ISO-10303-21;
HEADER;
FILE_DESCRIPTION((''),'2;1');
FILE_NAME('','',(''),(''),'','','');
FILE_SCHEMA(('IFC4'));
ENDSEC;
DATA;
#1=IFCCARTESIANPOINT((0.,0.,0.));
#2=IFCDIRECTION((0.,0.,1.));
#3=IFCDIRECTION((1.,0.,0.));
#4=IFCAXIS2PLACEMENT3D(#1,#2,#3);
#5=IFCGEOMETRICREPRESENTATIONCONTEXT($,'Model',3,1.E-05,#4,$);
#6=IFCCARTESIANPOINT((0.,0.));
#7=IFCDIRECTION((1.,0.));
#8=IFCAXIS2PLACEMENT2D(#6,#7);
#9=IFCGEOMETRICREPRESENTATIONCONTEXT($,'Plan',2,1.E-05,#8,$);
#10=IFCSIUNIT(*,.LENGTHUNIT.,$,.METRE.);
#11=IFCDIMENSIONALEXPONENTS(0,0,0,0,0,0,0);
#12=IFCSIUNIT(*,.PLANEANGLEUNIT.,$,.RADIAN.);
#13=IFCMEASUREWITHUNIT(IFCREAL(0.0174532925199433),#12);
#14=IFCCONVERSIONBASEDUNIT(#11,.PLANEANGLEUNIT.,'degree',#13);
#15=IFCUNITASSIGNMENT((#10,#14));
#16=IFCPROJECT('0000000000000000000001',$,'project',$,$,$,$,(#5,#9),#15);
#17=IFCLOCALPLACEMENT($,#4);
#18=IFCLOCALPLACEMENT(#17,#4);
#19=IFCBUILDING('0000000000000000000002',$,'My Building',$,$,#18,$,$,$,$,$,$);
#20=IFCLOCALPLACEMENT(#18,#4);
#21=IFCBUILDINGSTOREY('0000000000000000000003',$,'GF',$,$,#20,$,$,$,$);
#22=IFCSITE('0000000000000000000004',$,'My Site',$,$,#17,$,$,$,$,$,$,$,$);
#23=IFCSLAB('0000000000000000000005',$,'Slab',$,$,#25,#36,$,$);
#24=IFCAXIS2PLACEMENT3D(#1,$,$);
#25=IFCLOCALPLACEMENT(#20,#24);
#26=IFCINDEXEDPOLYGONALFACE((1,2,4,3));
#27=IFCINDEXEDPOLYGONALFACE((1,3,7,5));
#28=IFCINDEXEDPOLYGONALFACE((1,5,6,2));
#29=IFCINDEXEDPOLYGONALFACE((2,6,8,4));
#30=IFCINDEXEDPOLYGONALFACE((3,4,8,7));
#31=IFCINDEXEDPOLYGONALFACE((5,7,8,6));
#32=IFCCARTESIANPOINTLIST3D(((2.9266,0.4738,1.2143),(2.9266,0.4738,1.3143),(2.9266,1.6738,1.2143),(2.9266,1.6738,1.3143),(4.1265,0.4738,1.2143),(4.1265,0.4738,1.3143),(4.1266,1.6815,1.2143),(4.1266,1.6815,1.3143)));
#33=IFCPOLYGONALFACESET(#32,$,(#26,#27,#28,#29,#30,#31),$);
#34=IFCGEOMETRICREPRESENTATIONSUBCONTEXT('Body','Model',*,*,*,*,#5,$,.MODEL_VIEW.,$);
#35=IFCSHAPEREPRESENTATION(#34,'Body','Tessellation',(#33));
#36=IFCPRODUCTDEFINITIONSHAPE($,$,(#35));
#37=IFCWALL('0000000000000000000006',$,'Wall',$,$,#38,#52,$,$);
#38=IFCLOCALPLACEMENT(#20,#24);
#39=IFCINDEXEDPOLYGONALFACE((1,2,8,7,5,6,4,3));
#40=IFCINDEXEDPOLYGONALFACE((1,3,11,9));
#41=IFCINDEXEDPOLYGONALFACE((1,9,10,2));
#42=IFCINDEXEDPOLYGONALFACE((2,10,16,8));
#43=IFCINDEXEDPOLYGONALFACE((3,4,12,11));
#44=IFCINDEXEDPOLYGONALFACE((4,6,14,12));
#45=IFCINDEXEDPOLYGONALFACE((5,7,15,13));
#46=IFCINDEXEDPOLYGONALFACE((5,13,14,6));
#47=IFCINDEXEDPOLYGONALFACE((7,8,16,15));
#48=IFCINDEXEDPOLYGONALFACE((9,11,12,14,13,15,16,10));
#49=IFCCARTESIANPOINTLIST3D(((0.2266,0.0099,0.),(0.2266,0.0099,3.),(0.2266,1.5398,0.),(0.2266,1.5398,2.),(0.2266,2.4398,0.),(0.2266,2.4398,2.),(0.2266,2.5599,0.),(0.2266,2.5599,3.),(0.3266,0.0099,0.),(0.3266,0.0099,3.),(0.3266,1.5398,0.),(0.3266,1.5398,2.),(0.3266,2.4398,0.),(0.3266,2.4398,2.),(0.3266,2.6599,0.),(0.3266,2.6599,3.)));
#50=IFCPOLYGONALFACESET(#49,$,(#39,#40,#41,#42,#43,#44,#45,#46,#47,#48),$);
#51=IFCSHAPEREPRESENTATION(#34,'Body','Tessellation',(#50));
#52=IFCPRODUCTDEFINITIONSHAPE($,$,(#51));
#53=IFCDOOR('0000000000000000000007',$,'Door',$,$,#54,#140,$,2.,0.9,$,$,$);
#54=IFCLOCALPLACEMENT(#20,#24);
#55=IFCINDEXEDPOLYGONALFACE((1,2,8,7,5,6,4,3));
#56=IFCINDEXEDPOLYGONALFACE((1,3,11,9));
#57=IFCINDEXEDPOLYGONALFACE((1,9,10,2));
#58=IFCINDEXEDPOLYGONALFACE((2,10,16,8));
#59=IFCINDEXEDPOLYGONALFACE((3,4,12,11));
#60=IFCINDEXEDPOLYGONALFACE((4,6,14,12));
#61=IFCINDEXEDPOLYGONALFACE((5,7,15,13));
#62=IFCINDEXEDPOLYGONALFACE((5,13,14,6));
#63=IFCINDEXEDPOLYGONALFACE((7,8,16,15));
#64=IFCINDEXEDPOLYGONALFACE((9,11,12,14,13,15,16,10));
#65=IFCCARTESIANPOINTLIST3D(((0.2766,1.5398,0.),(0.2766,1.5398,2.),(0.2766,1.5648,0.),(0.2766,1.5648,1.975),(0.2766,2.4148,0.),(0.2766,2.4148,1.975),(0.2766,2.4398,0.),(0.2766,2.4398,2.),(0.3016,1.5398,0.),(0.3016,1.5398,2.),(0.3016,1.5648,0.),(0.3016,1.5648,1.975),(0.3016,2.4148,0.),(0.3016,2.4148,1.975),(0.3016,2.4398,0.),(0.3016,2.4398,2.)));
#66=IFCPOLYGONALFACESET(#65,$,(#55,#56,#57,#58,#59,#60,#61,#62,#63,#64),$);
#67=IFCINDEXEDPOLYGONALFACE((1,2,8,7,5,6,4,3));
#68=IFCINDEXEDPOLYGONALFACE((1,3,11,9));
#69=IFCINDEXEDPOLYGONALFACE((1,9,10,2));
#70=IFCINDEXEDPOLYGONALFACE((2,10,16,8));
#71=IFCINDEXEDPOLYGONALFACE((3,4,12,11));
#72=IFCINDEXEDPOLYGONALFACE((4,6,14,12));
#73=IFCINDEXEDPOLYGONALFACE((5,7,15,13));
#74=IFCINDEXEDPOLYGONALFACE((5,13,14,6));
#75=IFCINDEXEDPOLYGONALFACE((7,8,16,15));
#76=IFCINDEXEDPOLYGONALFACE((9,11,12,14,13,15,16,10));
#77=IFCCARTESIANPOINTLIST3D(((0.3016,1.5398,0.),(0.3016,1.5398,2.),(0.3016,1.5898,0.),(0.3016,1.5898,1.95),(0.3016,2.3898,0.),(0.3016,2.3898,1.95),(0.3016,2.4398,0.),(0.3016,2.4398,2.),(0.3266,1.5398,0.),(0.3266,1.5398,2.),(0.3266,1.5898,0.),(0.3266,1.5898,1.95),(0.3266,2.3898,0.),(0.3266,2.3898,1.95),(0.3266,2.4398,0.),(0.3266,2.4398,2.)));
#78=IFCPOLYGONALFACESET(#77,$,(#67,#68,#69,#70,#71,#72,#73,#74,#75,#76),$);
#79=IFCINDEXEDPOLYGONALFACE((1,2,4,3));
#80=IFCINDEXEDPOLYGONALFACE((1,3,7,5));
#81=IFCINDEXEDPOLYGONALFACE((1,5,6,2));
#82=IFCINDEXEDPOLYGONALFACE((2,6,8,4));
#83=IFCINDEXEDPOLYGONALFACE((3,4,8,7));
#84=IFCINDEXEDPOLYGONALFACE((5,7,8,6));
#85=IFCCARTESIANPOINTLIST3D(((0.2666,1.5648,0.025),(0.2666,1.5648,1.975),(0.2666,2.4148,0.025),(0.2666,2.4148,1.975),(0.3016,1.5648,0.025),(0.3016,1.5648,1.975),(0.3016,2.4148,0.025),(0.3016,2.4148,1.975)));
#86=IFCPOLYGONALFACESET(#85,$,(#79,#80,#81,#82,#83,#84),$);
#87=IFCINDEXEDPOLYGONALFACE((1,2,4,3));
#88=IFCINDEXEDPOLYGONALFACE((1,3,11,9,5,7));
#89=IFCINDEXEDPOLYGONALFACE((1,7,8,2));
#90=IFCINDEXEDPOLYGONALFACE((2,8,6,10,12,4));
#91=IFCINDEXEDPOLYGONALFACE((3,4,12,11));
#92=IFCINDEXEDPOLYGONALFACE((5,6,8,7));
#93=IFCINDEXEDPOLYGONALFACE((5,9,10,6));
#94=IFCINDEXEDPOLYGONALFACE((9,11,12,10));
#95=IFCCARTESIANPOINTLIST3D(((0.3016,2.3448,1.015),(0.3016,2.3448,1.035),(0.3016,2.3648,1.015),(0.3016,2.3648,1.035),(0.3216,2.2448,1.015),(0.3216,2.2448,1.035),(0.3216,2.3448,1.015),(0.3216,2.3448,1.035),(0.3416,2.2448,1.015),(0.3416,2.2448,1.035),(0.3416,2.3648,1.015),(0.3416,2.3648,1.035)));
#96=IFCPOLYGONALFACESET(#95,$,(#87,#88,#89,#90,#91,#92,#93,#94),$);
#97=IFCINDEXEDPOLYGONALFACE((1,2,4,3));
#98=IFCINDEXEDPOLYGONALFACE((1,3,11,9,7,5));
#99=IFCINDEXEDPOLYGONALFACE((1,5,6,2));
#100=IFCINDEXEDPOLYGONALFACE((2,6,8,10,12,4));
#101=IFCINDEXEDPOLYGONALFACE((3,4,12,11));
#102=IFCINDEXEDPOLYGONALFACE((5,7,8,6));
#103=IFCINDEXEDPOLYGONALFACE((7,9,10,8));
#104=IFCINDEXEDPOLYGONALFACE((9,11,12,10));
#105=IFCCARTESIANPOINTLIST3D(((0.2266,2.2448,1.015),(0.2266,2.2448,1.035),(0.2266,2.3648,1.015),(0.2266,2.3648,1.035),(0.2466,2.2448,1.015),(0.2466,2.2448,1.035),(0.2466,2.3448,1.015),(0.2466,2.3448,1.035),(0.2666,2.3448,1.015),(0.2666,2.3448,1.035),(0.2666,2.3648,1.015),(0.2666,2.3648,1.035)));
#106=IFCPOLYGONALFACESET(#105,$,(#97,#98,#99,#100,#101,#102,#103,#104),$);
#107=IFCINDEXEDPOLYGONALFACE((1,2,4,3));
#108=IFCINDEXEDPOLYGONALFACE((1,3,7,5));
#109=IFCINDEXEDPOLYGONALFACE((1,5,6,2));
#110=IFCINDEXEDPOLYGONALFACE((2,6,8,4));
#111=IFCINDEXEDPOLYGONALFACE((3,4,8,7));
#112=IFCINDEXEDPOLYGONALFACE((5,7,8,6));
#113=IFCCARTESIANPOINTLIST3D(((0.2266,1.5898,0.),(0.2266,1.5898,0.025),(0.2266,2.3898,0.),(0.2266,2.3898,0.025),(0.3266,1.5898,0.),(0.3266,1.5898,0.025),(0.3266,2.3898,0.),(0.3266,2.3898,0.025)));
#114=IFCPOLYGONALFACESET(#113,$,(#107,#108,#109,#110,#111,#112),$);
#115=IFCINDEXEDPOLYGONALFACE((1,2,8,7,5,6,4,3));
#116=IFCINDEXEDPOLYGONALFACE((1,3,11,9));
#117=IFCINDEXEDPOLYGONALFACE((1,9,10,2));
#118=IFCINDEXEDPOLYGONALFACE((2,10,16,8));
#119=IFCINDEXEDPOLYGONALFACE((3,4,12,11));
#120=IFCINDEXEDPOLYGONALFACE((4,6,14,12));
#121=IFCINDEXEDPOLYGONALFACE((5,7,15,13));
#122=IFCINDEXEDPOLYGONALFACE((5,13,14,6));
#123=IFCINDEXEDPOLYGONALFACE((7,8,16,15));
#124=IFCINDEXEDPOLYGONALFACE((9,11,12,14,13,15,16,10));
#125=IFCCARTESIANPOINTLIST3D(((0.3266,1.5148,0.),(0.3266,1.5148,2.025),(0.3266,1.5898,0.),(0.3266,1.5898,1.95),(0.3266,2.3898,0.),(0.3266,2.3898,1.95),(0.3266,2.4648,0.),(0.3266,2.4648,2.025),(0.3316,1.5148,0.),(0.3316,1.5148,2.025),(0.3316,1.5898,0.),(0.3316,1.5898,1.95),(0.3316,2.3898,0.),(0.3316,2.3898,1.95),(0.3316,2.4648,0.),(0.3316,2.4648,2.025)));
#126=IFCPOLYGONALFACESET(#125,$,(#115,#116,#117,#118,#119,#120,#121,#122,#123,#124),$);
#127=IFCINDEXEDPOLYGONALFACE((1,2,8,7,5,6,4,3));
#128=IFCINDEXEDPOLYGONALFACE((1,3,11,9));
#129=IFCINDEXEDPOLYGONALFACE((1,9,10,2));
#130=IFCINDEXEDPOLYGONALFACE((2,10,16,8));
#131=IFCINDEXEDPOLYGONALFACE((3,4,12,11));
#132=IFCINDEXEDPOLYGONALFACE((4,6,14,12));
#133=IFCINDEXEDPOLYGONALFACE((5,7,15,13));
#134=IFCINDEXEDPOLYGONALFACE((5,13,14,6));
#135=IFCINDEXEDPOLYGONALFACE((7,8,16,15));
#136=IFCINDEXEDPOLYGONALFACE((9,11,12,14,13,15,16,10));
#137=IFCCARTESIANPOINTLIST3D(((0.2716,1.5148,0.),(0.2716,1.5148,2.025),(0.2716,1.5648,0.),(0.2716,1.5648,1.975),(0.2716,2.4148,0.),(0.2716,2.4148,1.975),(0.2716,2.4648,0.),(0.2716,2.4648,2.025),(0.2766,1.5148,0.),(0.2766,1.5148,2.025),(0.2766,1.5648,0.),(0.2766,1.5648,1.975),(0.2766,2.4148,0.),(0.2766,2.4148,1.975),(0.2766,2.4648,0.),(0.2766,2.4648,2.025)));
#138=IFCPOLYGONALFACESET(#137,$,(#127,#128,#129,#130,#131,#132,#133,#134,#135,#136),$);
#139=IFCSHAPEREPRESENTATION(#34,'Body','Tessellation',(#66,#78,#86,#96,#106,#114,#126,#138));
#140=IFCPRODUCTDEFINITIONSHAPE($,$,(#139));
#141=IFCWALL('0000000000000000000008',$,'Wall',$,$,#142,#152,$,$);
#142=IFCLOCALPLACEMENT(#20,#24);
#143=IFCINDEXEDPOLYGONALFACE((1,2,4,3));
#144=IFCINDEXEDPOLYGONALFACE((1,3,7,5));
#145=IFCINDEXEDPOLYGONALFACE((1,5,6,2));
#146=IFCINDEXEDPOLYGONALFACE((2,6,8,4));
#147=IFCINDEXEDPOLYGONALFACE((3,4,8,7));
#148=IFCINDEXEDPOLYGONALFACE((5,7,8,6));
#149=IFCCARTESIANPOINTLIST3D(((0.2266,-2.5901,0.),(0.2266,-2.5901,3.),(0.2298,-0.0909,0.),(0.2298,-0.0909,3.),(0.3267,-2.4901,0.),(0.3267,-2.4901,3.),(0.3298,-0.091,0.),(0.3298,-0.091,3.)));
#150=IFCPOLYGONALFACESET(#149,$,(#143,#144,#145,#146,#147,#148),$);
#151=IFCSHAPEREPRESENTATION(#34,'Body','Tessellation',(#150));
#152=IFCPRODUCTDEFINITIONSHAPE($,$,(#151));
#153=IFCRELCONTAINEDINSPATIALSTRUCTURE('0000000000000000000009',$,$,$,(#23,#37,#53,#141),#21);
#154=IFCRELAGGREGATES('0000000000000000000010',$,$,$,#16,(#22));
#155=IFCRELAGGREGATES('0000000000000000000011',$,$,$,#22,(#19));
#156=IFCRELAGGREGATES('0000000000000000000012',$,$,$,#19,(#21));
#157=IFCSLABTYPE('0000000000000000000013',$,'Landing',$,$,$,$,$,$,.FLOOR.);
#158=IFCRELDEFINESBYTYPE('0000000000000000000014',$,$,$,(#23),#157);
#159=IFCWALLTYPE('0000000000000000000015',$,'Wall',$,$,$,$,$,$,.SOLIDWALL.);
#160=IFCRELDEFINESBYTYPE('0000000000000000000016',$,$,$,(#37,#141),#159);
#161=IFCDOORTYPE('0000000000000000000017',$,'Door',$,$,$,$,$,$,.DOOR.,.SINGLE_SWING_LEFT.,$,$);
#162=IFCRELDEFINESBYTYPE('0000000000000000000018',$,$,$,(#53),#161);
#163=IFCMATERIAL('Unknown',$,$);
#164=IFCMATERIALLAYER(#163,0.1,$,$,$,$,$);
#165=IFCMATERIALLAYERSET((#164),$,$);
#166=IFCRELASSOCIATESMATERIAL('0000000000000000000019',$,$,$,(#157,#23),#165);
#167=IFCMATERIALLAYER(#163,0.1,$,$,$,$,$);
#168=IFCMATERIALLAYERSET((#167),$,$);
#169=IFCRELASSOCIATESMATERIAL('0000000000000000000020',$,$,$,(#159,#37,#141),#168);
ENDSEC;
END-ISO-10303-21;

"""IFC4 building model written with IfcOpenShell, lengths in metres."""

from ifc_helpers import new_model, entity, si_unit, converted_unit, frame, origin_with_axes, origin_2d_with_axis, place, context, subcontext, project, spatial, line, indexed_curve, outline, extrude, shape, source, transform, mapped, material, layer, layer_set, layer_usage, type_object, type_shapes, element, fill, save


model = new_model("IFC4")

# Units and contexts
model_context = context("Model", 3, precision=1e-05, world=origin_with_axes())
plan_context = context("Plan", 2, precision=1e-05, world=origin_2d_with_axis())
body_context_1 = subcontext(model_context, "Body", "Model", "MODEL_VIEW")
body_context_2 = subcontext(plan_context, "Body", "Plan", "PLAN_VIEW")
ifc_project = project(units=[si_unit("LENGTHUNIT", "METRE"), converted_unit("PLANEANGLEUNIT", "degree", entity("IfcReal", 0.0174532925199433), si_unit("PLANEANGLEUNIT", "RADIAN"), dimensions=[0, 0, 0, 0, 0, 0, 0])], contexts=[model_context, plan_context])

# Site, building, storey
site_placement = place(None, origin_with_axes())
site = spatial("IfcSite", under=ifc_project, at=site_placement, Name="My Site")
building_placement = place(site_placement, origin_with_axes())
building = spatial("IfcBuilding", under=site, at=building_placement, Name="My Building")
storey_placement = place(building_placement, origin_with_axes())
storey = spatial("IfcBuildingStorey", under=building, at=storey_placement, Name="GF")

# Shared definitions
ifc_material_1 = material(Name="Unknown")

# Slab
ifc_layer_1 = layer(ifc_material_1, 0.1)
ifc_layer_set_1 = layer_set([ifc_layer_1])
ifc_layer_usage_1 = layer_usage(ifc_layer_set_1, "AXIS3", "POSITIVE", -0.1)
slab_type = type_object("IfcSlabType", Name="Landing", PredefinedType="FLOOR", material=ifc_layer_set_1)
slab_placement = place(storey_placement, frame((4.1266, 1.6815, 1.3143), z_axis=(0.0, 0.0, 1.0), x_axis=(1.0, 0.0, 0.0)))
element("IfcSlab", 1, at=slab_placement, inside=storey, type_object=slab_type, material=ifc_layer_usage_1, Name="Slab", context=body_context_1, shape_type="SweptSolid", body=[
    extrude(outline(indexed_curve([(0.0, 0.0), (-1.2, -0.0076), (-1.2, -1.2076), (-0.0001, -1.2076), (0.0, 0.0)])), frame((0.0, 0.0, -0.1), z_axis=(0.0, 0.0, 1.0), x_axis=(1.0, 0.0, 0.0)), (0.0, 0.0, 1.0), 0.1),
])

# Wall, opening, door
ifc_layer_2 = layer(ifc_material_1, 0.1)
ifc_layer_set_2 = layer_set([ifc_layer_2])
ifc_layer_usage_2 = layer_usage(ifc_layer_set_2, "AXIS2", "POSITIVE", 0.0)
wall_type = type_object("IfcWallType", Name="Wall", PredefinedType="SOLIDWALL", material=ifc_layer_set_2)
wall_1_placement = place(storey_placement, frame((0.3266, 0.0099, 0.0), z_axis=(0.0, 0.0, 1.0), x_axis=(0.0, 1.0, 0.0)))
wall_1 = element("IfcWall", 2, at=wall_1_placement, inside=storey, type_object=wall_type, material=ifc_layer_usage_2, Name="Wall", context=body_context_1, shape_type="SweptSolid", body=[
    extrude(outline(indexed_curve([(0.0, 0.0), (0.0, 0.1), (2.55, 0.1), (2.65, 0.0)], segments=[line(1, 2, 3, 4, 1)])), origin_with_axes(), (0.0, 0.0, 1.0), 3.0),
])
shared_shape_1 = source(origin_with_axes(), body_context_1, "Body", "SweptSolid", [
    extrude(outline(indexed_curve([(0.0, 0.0), (0.9, 0.0), (0.9, 2.0), (0.0, 2.0)], segments=[line(1, 2, 3, 4, 1)])), frame((0.0, -0.6, 0.0), z_axis=(0.0, -1.0, 0.0), x_axis=(1.0, 0.0, 0.0)), (0.0, 0.0, -1.0), 1.2),
])
opening_1_placement = place(wall_1_placement, frame((1.5299, 0.0, 0.0), z_axis=(0.0, 0.0, 1.0), x_axis=(1.0, 0.0, 0.0)))
opening_1 = element("IfcOpeningElement", 3, at=opening_1_placement, cuts=wall_1, PredefinedType="OPENING", context=body_context_1, shape_type="MappedRepresentation", body=[
    mapped(shared_shape_1, transform((0.0, 0.0, 0.0), x_axis=(1.0, 0.0, 0.0), y_axis=(0.0, 1.0, 0.0), z_axis=(0.0, 0.0, 1.0), scale=1.0)),
])
door_type = type_object("IfcDoorType", Name="Door", OperationType="SINGLE_SWING_LEFT", PredefinedType="DOOR")
shared_shape_2 = source(origin_with_axes(), body_context_1, "Body", "SweptSolid", [
    extrude(outline(indexed_curve([(0.0, 0.0), (0.0, 2.0), (0.9, 2.0), (0.9, 0.0), (0.875, 0.0), (0.875, 1.975), (0.025, 1.975), (0.025, 0.0)], segments=[line(1, 2, 3, 4, 5, 6, 7, 8, 1)])), frame((0.0, 0.025, 0.0), z_axis=(0.0, -1.0, 0.0), x_axis=(1.0, 0.0, 0.0)), (0.0, 0.0, -1.0), 0.025),
    extrude(outline(indexed_curve([(0.0, 0.0), (0.0, 2.0), (0.9, 2.0), (0.9, 0.0), (0.85, 0.0), (0.85, 1.95), (0.05, 1.95), (0.05, 0.0)], segments=[line(1, 2, 3, 4, 5, 6, 7, 8, 1)])), frame((0.0, 0.0, 0.0), z_axis=(0.0, -1.0, 0.0), x_axis=(1.0, 0.0, 0.0)), (0.0, 0.0, -1.0), 0.025),
    extrude(outline(indexed_curve([(0.0, 0.0), (0.85, 0.0), (0.85, 0.035), (0.0, 0.035)], segments=[line(1, 2, 3, 4, 1)])), frame((0.025, 0.025, 0.025), z_axis=(0.0, 0.0, 1.0), x_axis=(1.0, 0.0, 0.0)), (0.0, 0.0, 1.0), 1.95),
    extrude(outline(indexed_curve([(0.0, 0.0), (0.0, -0.04), (-0.12, -0.04), (-0.12, -0.02), (-0.02, -0.02), (-0.02, 0.0)], segments=[line(1, 2, 3, 4, 5, 6, 1)])), frame((0.825, 0.025, 1.015), z_axis=(0.0, 0.0, 1.0), x_axis=(1.0, 0.0, 0.0)), (0.0, 0.0, 1.0), 0.02),
    extrude(outline(indexed_curve([(0.0, 0.0), (0.0, 0.04), (-0.12, 0.04), (-0.12, 0.02), (-0.02, 0.02), (-0.02, 0.0)], segments=[line(1, 2, 3, 4, 5, 6, 1)])), frame((0.825, 0.06, 1.015), z_axis=(0.0, 0.0, 1.0), x_axis=(1.0, 0.0, 0.0)), (0.0, 0.0, 1.0), 0.02),
    extrude(outline(indexed_curve([(0.0, 0.0), (0.8, 0.0), (0.8, 0.1), (0.0, 0.1)], segments=[line(1, 2, 3, 4, 1)])), frame((0.05, 0.0, 0.0), z_axis=(0.0, 0.0, 1.0), x_axis=(1.0, 0.0, 0.0)), (0.0, 0.0, 1.0), 0.025),
    extrude(outline(indexed_curve([(0.0, 0.0), (0.0, 2.025), (0.95, 2.025), (0.95, 0.0), (0.875, 0.0), (0.875, 1.95), (0.075, 1.95), (0.075, 0.0)], segments=[line(1, 2, 3, 4, 5, 6, 7, 8, 1)])), frame((-0.025, -0.005, 0.0), z_axis=(0.0, -1.0, 0.0), x_axis=(1.0, 0.0, 0.0)), (0.0, 0.0, -1.0), 0.005),
    extrude(outline(indexed_curve([(0.0, 0.0), (0.0, 2.025), (0.95, 2.025), (0.95, 0.0), (0.9, 0.0), (0.9, 1.975), (0.05, 1.975), (0.05, 0.0)], segments=[line(1, 2, 3, 4, 5, 6, 7, 8, 1)])), frame((-0.025, 0.05, 0.0), z_axis=(0.0, -1.0, 0.0), x_axis=(1.0, 0.0, 0.0)), (0.0, 0.0, -1.0), 0.005),
])
shared_shape_3 = source(origin_with_axes(), body_context_2, "Body", "Curve2D", [
    entity("IfcIndexedPolyCurve", entity("IfcCartesianPointList2D", [[0.0, 0.0], [0.0, 0.05], [0.025, 0.05], [0.025, 0.025], [0.05, 0.025], [0.05, 0.0]]), [entity("IfcLineIndex", [1, 2, 3, 4, 5, 6, 1])]),
    entity("IfcIndexedPolyCurve", entity("IfcCartesianPointList2D", [[0.9, 0.0], [0.9, 0.05], [0.875, 0.05], [0.875, 0.025], [0.85, 0.025], [0.85, 0.0]]), [entity("IfcLineIndex", [1, 2, 3, 4, 5, 6, 1])]),
    entity("IfcTrimmedCurve", entity("IfcEllipse", entity("IfcAxis2Placement2D", entity("IfcCartesianPoint", [0.06, 0.05]), entity("IfcDirection", [1.0, 0.0])), 0.815, 0.85), [entity("IfcCartesianPoint", [0.875, 0.05])], [entity("IfcCartesianPoint", [0.06, 0.9])], True, "CARTESIAN"),
    entity("IfcIndexedPolyCurve", entity("IfcCartesianPointList2D", [[0.025, 0.05], [0.06, 0.05], [0.06, 0.9], [0.025, 0.9]]), [entity("IfcLineIndex", [1, 2, 3, 4, 1])]),
])
type_shapes(door_type, [shared_shape_2, shared_shape_3])
door_1_placement = place(opening_1_placement, frame((0.0, 0.0, 0.0), z_axis=(0.0, 0.0, 1.0), x_axis=(1.0, 0.0, 0.0)))
door_1 = element("IfcDoor", 4, at=door_1_placement, inside=storey, type_object=door_type, Name="Door", OverallHeight=2.0, OverallWidth=0.9, shapes=[
    shape(body_context_1, "Body", "MappedRepresentation", [mapped(shared_shape_2, transform((0.0, 0.0, 0.0), x_axis=(1.0, 0.0, 0.0), y_axis=(0.0, 1.0, 0.0), z_axis=(0.0, 0.0, 1.0), scale=1.0))]),
    shape(body_context_2, "Body", "MappedRepresentation", [mapped(shared_shape_3, transform((0.0, 0.0, 0.0), x_axis=(1.0, 0.0, 0.0), y_axis=(0.0, 1.0, 0.0), z_axis=(0.0, 0.0, 1.0), scale=1.0))]),
])
fill(opening_1, door_1)

# Wall
ifc_layer_usage_3 = layer_usage(ifc_layer_set_2, "AXIS2", "POSITIVE", 0.0)
wall_2_placement = place(storey_placement, frame((0.2298, -0.0909, 0.0), z_axis=(0.0, 0.0, 1.0), x_axis=(-0.001286, -0.999999, 0.0)))
element("IfcWall", 5, at=wall_2_placement, inside=storey, type_object=wall_type, material=ifc_layer_usage_3, Name="Wall", context=body_context_1, shape_type="SweptSolid", body=[
    extrude(outline(indexed_curve([(0.0, 0.0), (0.0, 0.1), (2.3991, 0.1), (2.4992, 0.0)], segments=[line(1, 2, 3, 4, 1)])), origin_with_axes(), (0.0, 0.0, 1.0), 3.0),
])

save(model, "model.ifc")
